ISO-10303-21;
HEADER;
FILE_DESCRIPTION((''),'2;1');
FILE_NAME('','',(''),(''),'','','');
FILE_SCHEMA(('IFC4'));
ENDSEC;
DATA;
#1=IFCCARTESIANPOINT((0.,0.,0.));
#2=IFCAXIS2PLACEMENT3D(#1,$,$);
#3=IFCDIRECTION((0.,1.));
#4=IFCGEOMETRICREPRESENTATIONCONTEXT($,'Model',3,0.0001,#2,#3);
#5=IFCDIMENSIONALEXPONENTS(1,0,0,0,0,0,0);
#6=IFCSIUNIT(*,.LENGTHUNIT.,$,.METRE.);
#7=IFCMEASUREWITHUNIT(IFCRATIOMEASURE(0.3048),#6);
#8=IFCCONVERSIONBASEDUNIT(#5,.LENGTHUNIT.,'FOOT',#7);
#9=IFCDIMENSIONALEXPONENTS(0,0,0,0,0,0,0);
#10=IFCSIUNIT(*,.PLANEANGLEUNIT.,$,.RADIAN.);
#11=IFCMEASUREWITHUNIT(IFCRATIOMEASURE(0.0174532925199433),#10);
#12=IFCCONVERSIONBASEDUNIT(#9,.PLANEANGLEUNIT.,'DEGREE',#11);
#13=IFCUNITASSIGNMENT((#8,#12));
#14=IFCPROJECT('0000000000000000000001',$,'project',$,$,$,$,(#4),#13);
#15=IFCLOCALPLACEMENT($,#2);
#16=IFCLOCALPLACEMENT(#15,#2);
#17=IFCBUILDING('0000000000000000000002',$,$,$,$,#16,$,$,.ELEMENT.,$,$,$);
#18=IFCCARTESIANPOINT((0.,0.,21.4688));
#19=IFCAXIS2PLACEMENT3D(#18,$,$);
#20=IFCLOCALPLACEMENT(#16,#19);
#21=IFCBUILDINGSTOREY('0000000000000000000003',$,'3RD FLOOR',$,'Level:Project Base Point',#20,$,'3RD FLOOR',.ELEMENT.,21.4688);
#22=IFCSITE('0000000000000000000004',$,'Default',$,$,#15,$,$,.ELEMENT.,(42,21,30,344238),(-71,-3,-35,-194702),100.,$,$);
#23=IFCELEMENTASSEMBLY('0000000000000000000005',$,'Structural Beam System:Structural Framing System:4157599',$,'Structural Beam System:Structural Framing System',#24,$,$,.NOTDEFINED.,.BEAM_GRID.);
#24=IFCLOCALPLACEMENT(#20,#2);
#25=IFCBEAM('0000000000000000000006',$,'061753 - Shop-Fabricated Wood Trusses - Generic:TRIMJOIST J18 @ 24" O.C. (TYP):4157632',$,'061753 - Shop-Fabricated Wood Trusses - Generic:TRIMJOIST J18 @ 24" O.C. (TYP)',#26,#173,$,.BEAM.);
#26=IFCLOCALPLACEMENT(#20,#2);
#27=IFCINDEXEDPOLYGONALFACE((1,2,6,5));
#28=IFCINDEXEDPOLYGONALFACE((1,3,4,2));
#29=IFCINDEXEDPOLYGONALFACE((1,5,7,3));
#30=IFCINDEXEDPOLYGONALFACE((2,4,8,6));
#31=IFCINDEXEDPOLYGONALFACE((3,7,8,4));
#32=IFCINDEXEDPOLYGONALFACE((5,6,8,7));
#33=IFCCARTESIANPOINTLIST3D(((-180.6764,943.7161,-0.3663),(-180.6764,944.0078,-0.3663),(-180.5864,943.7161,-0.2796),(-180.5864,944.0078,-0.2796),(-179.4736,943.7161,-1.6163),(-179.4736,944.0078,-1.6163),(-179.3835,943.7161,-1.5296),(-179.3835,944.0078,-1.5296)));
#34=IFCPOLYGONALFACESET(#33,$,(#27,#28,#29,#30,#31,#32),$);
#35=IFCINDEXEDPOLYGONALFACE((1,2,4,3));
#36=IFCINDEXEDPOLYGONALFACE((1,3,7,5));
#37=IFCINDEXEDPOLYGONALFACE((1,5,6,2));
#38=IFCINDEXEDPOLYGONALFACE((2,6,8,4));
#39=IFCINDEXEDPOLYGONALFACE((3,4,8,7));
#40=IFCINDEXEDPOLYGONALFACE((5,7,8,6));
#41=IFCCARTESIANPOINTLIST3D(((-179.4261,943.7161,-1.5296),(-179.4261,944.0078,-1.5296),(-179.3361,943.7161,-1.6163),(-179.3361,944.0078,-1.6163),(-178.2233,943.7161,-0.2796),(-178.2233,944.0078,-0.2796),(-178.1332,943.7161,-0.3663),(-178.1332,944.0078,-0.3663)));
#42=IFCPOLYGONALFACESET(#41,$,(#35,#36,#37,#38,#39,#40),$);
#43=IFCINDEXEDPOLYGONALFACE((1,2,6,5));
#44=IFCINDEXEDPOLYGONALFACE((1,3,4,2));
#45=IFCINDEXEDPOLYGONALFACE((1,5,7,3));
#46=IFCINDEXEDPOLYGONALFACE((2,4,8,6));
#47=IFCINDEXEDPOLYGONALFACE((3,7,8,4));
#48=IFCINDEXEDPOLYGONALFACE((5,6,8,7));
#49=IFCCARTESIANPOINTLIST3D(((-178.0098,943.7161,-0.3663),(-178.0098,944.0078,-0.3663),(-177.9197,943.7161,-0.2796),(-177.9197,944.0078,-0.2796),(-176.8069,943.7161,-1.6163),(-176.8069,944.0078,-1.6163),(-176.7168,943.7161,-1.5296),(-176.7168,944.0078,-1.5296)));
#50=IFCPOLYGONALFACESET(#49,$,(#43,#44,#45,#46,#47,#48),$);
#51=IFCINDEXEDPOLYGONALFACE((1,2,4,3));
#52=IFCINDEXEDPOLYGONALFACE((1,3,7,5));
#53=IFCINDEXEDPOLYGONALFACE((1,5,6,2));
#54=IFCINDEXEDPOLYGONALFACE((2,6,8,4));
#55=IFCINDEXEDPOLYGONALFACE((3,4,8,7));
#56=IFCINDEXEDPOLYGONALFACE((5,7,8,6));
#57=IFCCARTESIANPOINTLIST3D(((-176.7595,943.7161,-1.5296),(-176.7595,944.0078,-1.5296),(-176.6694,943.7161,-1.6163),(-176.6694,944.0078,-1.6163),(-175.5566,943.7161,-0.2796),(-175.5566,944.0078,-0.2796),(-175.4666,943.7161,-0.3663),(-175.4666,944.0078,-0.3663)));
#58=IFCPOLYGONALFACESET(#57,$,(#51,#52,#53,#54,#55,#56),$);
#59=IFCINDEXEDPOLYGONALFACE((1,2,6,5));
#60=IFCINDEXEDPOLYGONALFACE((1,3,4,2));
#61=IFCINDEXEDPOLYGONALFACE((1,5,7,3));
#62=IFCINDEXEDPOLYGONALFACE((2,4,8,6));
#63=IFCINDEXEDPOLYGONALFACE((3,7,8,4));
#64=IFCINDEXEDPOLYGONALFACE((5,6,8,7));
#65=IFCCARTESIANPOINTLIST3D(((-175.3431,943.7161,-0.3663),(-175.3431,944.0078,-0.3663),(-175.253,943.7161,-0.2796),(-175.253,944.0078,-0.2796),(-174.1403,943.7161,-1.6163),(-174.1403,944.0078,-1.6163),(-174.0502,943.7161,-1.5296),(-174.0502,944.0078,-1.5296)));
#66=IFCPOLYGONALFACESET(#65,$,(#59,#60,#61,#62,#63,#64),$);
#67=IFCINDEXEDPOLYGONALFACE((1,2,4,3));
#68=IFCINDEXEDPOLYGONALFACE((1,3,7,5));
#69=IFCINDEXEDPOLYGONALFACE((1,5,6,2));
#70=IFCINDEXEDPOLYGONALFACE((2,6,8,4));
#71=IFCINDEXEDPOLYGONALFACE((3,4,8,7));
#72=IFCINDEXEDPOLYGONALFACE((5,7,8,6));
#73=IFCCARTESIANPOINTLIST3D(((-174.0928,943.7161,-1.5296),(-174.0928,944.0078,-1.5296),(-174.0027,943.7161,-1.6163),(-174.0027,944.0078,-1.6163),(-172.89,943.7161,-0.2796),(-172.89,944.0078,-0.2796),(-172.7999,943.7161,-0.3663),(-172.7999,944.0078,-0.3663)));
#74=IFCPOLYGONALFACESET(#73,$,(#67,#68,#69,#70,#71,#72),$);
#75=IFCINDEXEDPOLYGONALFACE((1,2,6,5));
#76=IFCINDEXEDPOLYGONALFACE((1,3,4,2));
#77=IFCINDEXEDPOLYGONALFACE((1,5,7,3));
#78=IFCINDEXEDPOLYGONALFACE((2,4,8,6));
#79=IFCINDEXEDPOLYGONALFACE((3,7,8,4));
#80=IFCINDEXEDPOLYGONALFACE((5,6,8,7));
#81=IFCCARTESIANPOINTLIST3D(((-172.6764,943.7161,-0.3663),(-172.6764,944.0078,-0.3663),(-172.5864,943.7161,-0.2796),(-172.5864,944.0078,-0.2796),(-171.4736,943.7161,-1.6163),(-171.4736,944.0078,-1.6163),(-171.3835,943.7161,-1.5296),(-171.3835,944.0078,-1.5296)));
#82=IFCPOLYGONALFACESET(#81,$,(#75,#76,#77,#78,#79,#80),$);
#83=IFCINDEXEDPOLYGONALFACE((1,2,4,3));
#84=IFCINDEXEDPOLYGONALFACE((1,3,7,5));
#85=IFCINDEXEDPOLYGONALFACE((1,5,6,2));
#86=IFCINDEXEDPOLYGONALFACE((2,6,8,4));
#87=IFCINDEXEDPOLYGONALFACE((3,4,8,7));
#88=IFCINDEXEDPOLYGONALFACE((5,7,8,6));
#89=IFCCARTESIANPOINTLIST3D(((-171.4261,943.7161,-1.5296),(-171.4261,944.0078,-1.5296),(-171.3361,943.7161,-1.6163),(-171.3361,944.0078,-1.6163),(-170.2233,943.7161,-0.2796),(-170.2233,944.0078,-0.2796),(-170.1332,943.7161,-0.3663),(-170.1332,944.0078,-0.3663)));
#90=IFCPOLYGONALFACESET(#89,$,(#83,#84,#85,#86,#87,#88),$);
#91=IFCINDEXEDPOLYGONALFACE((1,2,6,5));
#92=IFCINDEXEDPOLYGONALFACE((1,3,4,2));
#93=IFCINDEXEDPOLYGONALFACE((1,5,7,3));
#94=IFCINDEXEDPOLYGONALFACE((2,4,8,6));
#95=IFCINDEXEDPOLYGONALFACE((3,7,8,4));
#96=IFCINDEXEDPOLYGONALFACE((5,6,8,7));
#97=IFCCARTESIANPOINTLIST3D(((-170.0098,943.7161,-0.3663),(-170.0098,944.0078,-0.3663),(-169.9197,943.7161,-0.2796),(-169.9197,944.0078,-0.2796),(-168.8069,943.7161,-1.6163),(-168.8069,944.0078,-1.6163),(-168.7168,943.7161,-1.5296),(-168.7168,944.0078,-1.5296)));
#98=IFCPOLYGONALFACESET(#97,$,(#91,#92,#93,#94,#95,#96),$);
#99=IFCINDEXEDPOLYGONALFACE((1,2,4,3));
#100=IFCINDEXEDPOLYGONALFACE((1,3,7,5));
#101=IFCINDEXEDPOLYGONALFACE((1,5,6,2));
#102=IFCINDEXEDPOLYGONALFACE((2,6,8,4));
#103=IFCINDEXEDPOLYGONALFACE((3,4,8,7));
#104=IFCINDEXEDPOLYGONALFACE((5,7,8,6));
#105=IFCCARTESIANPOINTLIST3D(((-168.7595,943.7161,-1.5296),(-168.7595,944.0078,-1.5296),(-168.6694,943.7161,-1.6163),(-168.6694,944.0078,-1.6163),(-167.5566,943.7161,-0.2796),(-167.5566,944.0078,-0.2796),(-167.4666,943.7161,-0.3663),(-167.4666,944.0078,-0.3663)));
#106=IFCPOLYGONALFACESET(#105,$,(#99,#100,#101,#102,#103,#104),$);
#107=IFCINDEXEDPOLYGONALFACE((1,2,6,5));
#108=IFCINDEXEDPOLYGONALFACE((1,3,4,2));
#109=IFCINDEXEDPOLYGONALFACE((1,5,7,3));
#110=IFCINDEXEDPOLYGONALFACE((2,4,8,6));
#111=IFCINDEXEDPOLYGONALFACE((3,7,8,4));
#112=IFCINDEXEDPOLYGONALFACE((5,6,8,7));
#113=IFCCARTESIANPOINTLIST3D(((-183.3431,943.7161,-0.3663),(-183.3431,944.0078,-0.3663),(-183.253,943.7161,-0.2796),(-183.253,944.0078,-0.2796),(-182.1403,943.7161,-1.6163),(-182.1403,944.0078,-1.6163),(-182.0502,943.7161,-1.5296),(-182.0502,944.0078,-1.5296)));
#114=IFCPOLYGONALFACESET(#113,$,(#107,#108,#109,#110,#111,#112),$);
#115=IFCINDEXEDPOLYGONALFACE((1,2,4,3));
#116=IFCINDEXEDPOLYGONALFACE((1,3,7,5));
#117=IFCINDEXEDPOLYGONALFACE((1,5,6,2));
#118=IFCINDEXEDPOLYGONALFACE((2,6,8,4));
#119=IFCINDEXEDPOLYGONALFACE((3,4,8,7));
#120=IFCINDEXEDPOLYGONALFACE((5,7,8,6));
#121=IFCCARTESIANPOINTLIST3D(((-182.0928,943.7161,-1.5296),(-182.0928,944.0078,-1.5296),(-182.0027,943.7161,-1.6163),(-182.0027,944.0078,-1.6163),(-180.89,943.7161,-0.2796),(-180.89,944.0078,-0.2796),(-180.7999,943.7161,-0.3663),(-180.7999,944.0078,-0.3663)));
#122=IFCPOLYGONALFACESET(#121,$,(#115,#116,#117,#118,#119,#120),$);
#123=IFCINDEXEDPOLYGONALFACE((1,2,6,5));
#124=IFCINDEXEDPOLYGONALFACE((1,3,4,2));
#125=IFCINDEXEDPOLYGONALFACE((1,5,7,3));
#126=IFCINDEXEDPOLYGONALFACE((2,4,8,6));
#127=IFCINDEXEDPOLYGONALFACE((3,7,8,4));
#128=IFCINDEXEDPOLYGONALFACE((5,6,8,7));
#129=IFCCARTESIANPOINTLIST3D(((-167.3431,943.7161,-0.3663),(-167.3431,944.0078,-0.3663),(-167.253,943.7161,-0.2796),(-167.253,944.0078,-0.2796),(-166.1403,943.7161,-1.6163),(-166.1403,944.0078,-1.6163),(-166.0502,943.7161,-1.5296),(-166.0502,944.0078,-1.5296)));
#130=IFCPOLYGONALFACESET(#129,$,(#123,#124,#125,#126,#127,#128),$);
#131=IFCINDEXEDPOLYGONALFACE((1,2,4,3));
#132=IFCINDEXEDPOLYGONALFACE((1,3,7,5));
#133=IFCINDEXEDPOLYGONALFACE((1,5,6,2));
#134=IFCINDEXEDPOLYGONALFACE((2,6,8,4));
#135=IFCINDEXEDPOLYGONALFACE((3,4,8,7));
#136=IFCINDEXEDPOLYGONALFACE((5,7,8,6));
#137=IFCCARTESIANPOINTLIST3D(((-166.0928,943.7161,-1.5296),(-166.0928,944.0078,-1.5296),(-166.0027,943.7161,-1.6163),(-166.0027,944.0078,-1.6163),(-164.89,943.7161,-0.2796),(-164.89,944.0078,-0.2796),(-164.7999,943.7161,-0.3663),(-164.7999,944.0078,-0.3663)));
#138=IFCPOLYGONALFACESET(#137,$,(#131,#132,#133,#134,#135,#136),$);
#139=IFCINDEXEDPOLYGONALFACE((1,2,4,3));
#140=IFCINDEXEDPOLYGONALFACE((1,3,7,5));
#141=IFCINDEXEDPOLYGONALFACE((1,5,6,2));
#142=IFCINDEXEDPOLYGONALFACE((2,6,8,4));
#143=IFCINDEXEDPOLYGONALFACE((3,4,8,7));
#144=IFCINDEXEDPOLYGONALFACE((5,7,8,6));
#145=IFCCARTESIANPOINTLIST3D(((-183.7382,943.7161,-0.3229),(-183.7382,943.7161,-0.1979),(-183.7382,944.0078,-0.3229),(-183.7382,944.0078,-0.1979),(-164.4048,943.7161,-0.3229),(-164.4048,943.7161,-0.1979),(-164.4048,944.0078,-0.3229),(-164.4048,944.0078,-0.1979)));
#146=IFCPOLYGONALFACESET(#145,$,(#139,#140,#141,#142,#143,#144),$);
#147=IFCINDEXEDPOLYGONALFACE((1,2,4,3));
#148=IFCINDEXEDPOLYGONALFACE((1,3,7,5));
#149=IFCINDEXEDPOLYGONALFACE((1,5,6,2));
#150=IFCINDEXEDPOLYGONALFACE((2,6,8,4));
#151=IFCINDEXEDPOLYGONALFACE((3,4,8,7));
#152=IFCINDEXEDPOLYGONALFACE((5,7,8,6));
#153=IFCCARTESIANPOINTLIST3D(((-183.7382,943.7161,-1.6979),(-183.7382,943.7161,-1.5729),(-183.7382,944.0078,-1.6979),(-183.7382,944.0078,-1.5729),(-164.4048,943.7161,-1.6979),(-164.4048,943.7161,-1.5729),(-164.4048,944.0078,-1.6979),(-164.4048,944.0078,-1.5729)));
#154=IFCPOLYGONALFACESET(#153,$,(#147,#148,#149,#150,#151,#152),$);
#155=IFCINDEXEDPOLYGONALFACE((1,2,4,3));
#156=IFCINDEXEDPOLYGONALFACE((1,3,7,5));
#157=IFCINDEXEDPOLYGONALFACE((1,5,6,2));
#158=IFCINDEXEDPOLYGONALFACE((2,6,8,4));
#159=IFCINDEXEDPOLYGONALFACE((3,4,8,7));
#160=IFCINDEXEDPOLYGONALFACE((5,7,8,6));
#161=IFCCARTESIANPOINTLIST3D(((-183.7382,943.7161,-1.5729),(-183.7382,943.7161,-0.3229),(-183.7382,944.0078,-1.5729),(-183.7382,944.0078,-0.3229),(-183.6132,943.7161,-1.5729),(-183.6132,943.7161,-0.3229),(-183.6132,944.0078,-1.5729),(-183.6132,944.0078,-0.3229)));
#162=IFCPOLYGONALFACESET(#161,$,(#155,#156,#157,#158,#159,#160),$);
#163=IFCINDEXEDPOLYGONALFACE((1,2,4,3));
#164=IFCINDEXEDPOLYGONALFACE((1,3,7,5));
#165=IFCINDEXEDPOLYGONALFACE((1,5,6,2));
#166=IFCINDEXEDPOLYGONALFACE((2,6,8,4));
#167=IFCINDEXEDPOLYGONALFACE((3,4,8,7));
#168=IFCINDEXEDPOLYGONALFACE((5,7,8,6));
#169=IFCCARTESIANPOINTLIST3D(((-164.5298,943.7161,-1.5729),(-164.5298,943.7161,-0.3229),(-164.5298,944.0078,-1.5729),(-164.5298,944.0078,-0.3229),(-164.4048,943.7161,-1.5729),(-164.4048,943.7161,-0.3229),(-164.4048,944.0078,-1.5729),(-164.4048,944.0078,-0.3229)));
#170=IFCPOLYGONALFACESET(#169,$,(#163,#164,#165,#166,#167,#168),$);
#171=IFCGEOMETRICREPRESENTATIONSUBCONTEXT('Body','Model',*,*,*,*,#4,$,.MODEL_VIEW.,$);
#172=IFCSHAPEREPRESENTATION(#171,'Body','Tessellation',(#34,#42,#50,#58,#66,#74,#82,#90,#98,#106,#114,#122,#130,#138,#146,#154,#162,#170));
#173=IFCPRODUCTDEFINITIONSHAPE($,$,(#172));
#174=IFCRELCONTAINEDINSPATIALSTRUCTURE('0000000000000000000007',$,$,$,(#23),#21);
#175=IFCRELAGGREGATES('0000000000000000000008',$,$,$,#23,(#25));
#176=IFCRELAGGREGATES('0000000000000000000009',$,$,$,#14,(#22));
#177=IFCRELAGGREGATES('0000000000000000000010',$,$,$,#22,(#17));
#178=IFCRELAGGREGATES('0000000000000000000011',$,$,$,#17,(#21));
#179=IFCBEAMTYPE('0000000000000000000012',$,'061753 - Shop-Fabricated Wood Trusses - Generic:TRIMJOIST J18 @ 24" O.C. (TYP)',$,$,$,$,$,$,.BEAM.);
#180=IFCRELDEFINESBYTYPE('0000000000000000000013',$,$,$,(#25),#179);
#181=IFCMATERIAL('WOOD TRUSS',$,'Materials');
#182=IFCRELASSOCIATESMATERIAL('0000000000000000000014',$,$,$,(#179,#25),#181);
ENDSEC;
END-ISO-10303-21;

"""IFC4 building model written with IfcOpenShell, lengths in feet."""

from ifc_helpers import new_model, entity, si_unit, converted_unit, direction, frame, frame_2d, origin, origin_2d_with_axis, place, context, subcontext, project, spatial, rectangle, extrude, source, transform, mapped, material, material_profile, profile_set, profile_usage, type_object, type_shapes, element, aggregate, save


model = new_model("IFC4")

# Units and contexts
model_context = context("Model", 3, precision=0.0001, world=origin(), true_north=direction((0.0, 1.0)))
body_context = subcontext(model_context, "Body", "Model", "MODEL_VIEW")
ifc_project = project(units=[converted_unit("LENGTHUNIT", "FOOT", entity("IfcRatioMeasure", 0.3048), si_unit("LENGTHUNIT", "METRE"), dimensions=[1, 0, 0, 0, 0, 0, 0]), converted_unit("PLANEANGLEUNIT", "DEGREE", entity("IfcRatioMeasure", 0.0174532925199433), si_unit("PLANEANGLEUNIT", "RADIAN"), dimensions=[0, 0, 0, 0, 0, 0, 0])], contexts=[model_context])

# Site, building, storey
site_placement = place(None, origin())
site = spatial("IfcSite", under=ifc_project, at=site_placement, Name="Default", CompositionType="ELEMENT", RefLatitude=(42, 21, 30, 344238), RefLongitude=(-71, -3, -35, -194702), RefElevation=100.0)
building_placement = place(site_placement, origin())
building = spatial("IfcBuilding", under=site, at=building_placement, CompositionType="ELEMENT")
storey_placement = place(building_placement, frame((0.0, 0.0, 21.4688)))
storey = spatial("IfcBuildingStorey", under=building, at=storey_placement, Name="3RD FLOOR", ObjectType="Level:Project Base Point", LongName="3RD FLOOR", CompositionType="ELEMENT", Elevation=21.4688)

# Element assembly, beam
ifc_material = material(Name="WOOD TRUSS", Category="Materials")
ifc_material_profile_1 = material_profile(ifc_material, rectangle(XDim=1.7347, YDim=0.125, at=frame_2d((0.0, 0.0), x_axis=(1.0, 0.0))), Name="TRIMJOIST J18 @ 24\" O.C. (TYP)")
ifc_material_profile_2 = material_profile(ifc_material, rectangle(XDim=1.7347, YDim=0.125, at=frame_2d((0.0, 0.0), x_axis=(1.0, 0.0))), Name="TRIMJOIST J18 @ 24\" O.C. (TYP)")
ifc_material_profile_3 = material_profile(ifc_material, rectangle(XDim=1.7347, YDim=0.125, at=frame_2d((0.0, 0.0), x_axis=(1.0, 0.0))), Name="TRIMJOIST J18 @ 24\" O.C. (TYP)")
ifc_material_profile_4 = material_profile(ifc_material, rectangle(XDim=1.7347, YDim=0.125, at=frame_2d((0.0, 0.0), x_axis=(1.0, 0.0))), Name="TRIMJOIST J18 @ 24\" O.C. (TYP)")
ifc_material_profile_5 = material_profile(ifc_material, rectangle(XDim=1.7347, YDim=0.125, at=frame_2d((0.0, 0.0), x_axis=(1.0, 0.0))), Name="TRIMJOIST J18 @ 24\" O.C. (TYP)")
ifc_material_profile_6 = material_profile(ifc_material, rectangle(XDim=1.7347, YDim=0.125, at=frame_2d((0.0, 0.0), x_axis=(1.0, 0.0))), Name="TRIMJOIST J18 @ 24\" O.C. (TYP)")
ifc_material_profile_7 = material_profile(ifc_material, rectangle(XDim=1.7347, YDim=0.125, at=frame_2d((0.0, 0.0), x_axis=(1.0, 0.0))), Name="TRIMJOIST J18 @ 24\" O.C. (TYP)")
ifc_material_profile_8 = material_profile(ifc_material, rectangle(XDim=1.7347, YDim=0.125, at=frame_2d((0.0, 0.0), x_axis=(1.0, 0.0))), Name="TRIMJOIST J18 @ 24\" O.C. (TYP)")
ifc_material_profile_9 = material_profile(ifc_material, rectangle(XDim=1.7347, YDim=0.125, at=frame_2d((0.0, 0.0), x_axis=(1.0, 0.0))), Name="TRIMJOIST J18 @ 24\" O.C. (TYP)")
ifc_material_profile_10 = material_profile(ifc_material, rectangle(XDim=1.7347, YDim=0.125, at=origin_2d_with_axis()), Name="TRIMJOIST J18 @ 24\" O.C. (TYP)")
ifc_material_profile_11 = material_profile(ifc_material, rectangle(XDim=0.125, YDim=0.2917, at=origin_2d_with_axis()), Name="TRIMJOIST J18 @ 24\" O.C. (TYP)")
ifc_material_profile_12 = material_profile(ifc_material, rectangle(XDim=0.125, YDim=0.2917, at=origin_2d_with_axis()), Name="TRIMJOIST J18 @ 24\" O.C. (TYP)")
ifc_material_profile_13 = material_profile(ifc_material, rectangle(XDim=1.25, YDim=0.2917, at=origin_2d_with_axis()), Name="TRIMJOIST J18 @ 24\" O.C. (TYP)")
ifc_material_profile_14 = material_profile(ifc_material, rectangle(XDim=1.25, YDim=0.2917, at=origin_2d_with_axis()), Name="TRIMJOIST J18 @ 24\" O.C. (TYP)")
ifc_profile_set = profile_set([ifc_material_profile_1, ifc_material_profile_2, ifc_material_profile_3, ifc_material_profile_4, ifc_material_profile_5, ifc_material_profile_6, ifc_material_profile_7, ifc_material_profile_8, ifc_material_profile_9, ifc_material_profile_10, ifc_material_profile_11, ifc_material_profile_12, ifc_material_profile_13, ifc_material_profile_14], Name="TRIMJOIST J18 @ 24\" O.C. (TYP)")
assembly_1_placement = place(storey_placement, origin())
assembly_1 = element("IfcElementAssembly", 1, at=assembly_1_placement, inside=storey, Name="Structural Beam System:Structural Framing System:4157599", ObjectType="Structural Beam System:Structural Framing System", AssemblyPlace="NOTDEFINED", PredefinedType="BEAM_GRID")
beam_type_1 = type_object("IfcBeamType", Name="061753 - Shop-Fabricated Wood Trusses - Generic:TRIMJOIST J18 @ 24\" O.C. (TYP)", PredefinedType="BEAM", material=ifc_profile_set)
shared_shape_1 = source(origin(), body_context, "Body", "SweptSolid", [
    extrude(rectangle(XDim=1.7347, YDim=0.125, at=frame_2d((0.0, 0.0), x_axis=(1.0, 0.0))), frame((5.9585, -0.1458, 0.0), z_axis=(0.0, 1.0, 0.0), x_axis=(0.693383, 0.0, 0.720569)), (0.0, 0.0, 1.0), 0.2917),
    extrude(rectangle(XDim=1.7347, YDim=0.125, at=origin_2d_with_axis()), frame((4.7082, -0.1458, 0.0), z_axis=(0.0, 1.0, 0.0), x_axis=(0.693383, 0.0, -0.720569)), (0.0, 0.0, 1.0), 0.2917),
    extrude(rectangle(XDim=1.7347, YDim=0.125, at=frame_2d((0.0, 0.0), x_axis=(1.0, 0.0))), frame((3.2918, -0.1458, 0.0), z_axis=(0.0, 1.0, 0.0), x_axis=(0.693383, 0.0, 0.720569)), (0.0, 0.0, 1.0), 0.2917),
    extrude(rectangle(XDim=1.7347, YDim=0.125, at=frame_2d((0.0, 0.0), x_axis=(1.0, 0.0))), frame((2.0415, -0.1458, 0.0), z_axis=(0.0, 1.0, 0.0), x_axis=(0.693383, 0.0, -0.720569)), (0.0, 0.0, 1.0), 0.2917),
    extrude(rectangle(XDim=1.7347, YDim=0.125, at=frame_2d((0.0, 0.0), x_axis=(1.0, 0.0))), frame((0.6251, -0.1458, 0.0), z_axis=(0.0, 1.0, 0.0), x_axis=(0.693383, 0.0, 0.720569)), (0.0, 0.0, 1.0), 0.2917),
    extrude(rectangle(XDim=1.7347, YDim=0.125, at=frame_2d((0.0, 0.0), x_axis=(1.0, 0.0))), frame((-0.6251, -0.1458, 0.0), z_axis=(0.0, 1.0, 0.0), x_axis=(0.693383, 0.0, -0.720569)), (0.0, 0.0, 1.0), 0.2917),
    extrude(rectangle(XDim=1.7347, YDim=0.125, at=frame_2d((0.0, 0.0), x_axis=(1.0, 0.0))), frame((-2.0415, -0.1458, 0.0), z_axis=(0.0, 1.0, 0.0), x_axis=(0.693383, 0.0, 0.720569)), (0.0, 0.0, 1.0), 0.2917),
    extrude(rectangle(XDim=1.7347, YDim=0.125, at=origin_2d_with_axis()), frame((-3.2918, -0.1458, 0.0), z_axis=(0.0, 1.0, 0.0), x_axis=(0.693383, 0.0, -0.720569)), (0.0, 0.0, 1.0), 0.2917),
    extrude(rectangle(XDim=1.7347, YDim=0.125, at=frame_2d((0.0, 0.0), x_axis=(1.0, 0.0))), frame((-4.7082, -0.1458, 0.0), z_axis=(0.0, 1.0, 0.0), x_axis=(0.693383, 0.0, 0.720569)), (0.0, 0.0, 1.0), 0.2917),
    extrude(rectangle(XDim=1.7347, YDim=0.125, at=frame_2d((0.0, 0.0), x_axis=(1.0, 0.0))), frame((-5.9585, -0.1458, 0.0), z_axis=(0.0, 1.0, 0.0), x_axis=(0.693383, 0.0, -0.720569)), (0.0, 0.0, 1.0), 0.2917),
    extrude(rectangle(XDim=1.7347, YDim=0.125, at=frame_2d((0.0, 0.0), x_axis=(1.0, 0.0))), frame((8.6251, -0.1458, 0.0), z_axis=(0.0, 1.0, 0.0), x_axis=(0.693383, 0.0, 0.720569)), (0.0, 0.0, 1.0), 0.2917),
    extrude(rectangle(XDim=1.7347, YDim=0.125, at=origin_2d_with_axis()), frame((7.3749, -0.1458, 0.0), z_axis=(0.0, 1.0, 0.0), x_axis=(0.693383, 0.0, -0.720569)), (0.0, 0.0, 1.0), 0.2917),
    extrude(rectangle(XDim=1.7347, YDim=0.125, at=frame_2d((0.0, 0.0), x_axis=(1.0, 0.0))), frame((-7.3749, -0.1458, 0.0), z_axis=(0.0, 1.0, 0.0), x_axis=(0.693383, 0.0, 0.720569)), (0.0, 0.0, 1.0), 0.2917),
    extrude(rectangle(XDim=1.7347, YDim=0.125, at=origin_2d_with_axis()), frame((-8.6251, -0.1458, 0.0), z_axis=(0.0, 1.0, 0.0), x_axis=(0.693383, 0.0, -0.720569)), (0.0, 0.0, 1.0), 0.2917),
    extrude(rectangle(XDim=0.125, YDim=0.2917, at=origin_2d_with_axis()), frame((-9.6667, 0.0, 0.6875), z_axis=(1.0, 0.0, 0.0), x_axis=(0.0, 0.0, -1.0)), (0.0, 0.0, 1.0), 19.3333),
    extrude(rectangle(XDim=0.125, YDim=0.2917, at=origin_2d_with_axis()), frame((-9.6667, 0.0, -0.6875), z_axis=(1.0, 0.0, 0.0), x_axis=(0.0, 0.0, -1.0)), (0.0, 0.0, 1.0), 19.3333),
    extrude(rectangle(XDim=1.25, YDim=0.2917, at=origin_2d_with_axis()), frame((9.5417, 0.0, 0.0), z_axis=(1.0, 0.0, 0.0), x_axis=(0.0, 0.0, -1.0)), (0.0, 0.0, 1.0), 0.125),
    extrude(rectangle(XDim=1.25, YDim=0.2917, at=origin_2d_with_axis()), frame((-9.6667, 0.0, 0.0), z_axis=(1.0, 0.0, 0.0), x_axis=(0.0, 0.0, -1.0)), (0.0, 0.0, 1.0), 0.125),
])
type_shapes(beam_type_1, [shared_shape_1])
ifc_profile_usage_1 = profile_usage(ifc_profile_set, cardinal=8)
beam_1_placement = place(assembly_1_placement, frame((-174.0715, 943.8619, -0.9479), z_axis=(0.0, 0.0, 1.0), x_axis=(-1.0, 0.0, 0.0)))
beam_1 = element("IfcBeam", 2, at=beam_1_placement, type_object=beam_type_1, material=ifc_profile_usage_1, Name="061753 - Shop-Fabricated Wood Trusses - Generic:TRIMJOIST J18 @ 24\" O.C. (TYP):4157632", ObjectType="061753 - Shop-Fabricated Wood Trusses - Generic:TRIMJOIST J18 @ 24\" O.C. (TYP)", PredefinedType="BEAM", context=body_context, shape_type="MappedRepresentation", body=[
    mapped(shared_shape_1, transform((0.0, 0.0, 0.0), scale=1.0)),
])
aggregate(assembly_1, [beam_1])

save(model, "model.ifc")
